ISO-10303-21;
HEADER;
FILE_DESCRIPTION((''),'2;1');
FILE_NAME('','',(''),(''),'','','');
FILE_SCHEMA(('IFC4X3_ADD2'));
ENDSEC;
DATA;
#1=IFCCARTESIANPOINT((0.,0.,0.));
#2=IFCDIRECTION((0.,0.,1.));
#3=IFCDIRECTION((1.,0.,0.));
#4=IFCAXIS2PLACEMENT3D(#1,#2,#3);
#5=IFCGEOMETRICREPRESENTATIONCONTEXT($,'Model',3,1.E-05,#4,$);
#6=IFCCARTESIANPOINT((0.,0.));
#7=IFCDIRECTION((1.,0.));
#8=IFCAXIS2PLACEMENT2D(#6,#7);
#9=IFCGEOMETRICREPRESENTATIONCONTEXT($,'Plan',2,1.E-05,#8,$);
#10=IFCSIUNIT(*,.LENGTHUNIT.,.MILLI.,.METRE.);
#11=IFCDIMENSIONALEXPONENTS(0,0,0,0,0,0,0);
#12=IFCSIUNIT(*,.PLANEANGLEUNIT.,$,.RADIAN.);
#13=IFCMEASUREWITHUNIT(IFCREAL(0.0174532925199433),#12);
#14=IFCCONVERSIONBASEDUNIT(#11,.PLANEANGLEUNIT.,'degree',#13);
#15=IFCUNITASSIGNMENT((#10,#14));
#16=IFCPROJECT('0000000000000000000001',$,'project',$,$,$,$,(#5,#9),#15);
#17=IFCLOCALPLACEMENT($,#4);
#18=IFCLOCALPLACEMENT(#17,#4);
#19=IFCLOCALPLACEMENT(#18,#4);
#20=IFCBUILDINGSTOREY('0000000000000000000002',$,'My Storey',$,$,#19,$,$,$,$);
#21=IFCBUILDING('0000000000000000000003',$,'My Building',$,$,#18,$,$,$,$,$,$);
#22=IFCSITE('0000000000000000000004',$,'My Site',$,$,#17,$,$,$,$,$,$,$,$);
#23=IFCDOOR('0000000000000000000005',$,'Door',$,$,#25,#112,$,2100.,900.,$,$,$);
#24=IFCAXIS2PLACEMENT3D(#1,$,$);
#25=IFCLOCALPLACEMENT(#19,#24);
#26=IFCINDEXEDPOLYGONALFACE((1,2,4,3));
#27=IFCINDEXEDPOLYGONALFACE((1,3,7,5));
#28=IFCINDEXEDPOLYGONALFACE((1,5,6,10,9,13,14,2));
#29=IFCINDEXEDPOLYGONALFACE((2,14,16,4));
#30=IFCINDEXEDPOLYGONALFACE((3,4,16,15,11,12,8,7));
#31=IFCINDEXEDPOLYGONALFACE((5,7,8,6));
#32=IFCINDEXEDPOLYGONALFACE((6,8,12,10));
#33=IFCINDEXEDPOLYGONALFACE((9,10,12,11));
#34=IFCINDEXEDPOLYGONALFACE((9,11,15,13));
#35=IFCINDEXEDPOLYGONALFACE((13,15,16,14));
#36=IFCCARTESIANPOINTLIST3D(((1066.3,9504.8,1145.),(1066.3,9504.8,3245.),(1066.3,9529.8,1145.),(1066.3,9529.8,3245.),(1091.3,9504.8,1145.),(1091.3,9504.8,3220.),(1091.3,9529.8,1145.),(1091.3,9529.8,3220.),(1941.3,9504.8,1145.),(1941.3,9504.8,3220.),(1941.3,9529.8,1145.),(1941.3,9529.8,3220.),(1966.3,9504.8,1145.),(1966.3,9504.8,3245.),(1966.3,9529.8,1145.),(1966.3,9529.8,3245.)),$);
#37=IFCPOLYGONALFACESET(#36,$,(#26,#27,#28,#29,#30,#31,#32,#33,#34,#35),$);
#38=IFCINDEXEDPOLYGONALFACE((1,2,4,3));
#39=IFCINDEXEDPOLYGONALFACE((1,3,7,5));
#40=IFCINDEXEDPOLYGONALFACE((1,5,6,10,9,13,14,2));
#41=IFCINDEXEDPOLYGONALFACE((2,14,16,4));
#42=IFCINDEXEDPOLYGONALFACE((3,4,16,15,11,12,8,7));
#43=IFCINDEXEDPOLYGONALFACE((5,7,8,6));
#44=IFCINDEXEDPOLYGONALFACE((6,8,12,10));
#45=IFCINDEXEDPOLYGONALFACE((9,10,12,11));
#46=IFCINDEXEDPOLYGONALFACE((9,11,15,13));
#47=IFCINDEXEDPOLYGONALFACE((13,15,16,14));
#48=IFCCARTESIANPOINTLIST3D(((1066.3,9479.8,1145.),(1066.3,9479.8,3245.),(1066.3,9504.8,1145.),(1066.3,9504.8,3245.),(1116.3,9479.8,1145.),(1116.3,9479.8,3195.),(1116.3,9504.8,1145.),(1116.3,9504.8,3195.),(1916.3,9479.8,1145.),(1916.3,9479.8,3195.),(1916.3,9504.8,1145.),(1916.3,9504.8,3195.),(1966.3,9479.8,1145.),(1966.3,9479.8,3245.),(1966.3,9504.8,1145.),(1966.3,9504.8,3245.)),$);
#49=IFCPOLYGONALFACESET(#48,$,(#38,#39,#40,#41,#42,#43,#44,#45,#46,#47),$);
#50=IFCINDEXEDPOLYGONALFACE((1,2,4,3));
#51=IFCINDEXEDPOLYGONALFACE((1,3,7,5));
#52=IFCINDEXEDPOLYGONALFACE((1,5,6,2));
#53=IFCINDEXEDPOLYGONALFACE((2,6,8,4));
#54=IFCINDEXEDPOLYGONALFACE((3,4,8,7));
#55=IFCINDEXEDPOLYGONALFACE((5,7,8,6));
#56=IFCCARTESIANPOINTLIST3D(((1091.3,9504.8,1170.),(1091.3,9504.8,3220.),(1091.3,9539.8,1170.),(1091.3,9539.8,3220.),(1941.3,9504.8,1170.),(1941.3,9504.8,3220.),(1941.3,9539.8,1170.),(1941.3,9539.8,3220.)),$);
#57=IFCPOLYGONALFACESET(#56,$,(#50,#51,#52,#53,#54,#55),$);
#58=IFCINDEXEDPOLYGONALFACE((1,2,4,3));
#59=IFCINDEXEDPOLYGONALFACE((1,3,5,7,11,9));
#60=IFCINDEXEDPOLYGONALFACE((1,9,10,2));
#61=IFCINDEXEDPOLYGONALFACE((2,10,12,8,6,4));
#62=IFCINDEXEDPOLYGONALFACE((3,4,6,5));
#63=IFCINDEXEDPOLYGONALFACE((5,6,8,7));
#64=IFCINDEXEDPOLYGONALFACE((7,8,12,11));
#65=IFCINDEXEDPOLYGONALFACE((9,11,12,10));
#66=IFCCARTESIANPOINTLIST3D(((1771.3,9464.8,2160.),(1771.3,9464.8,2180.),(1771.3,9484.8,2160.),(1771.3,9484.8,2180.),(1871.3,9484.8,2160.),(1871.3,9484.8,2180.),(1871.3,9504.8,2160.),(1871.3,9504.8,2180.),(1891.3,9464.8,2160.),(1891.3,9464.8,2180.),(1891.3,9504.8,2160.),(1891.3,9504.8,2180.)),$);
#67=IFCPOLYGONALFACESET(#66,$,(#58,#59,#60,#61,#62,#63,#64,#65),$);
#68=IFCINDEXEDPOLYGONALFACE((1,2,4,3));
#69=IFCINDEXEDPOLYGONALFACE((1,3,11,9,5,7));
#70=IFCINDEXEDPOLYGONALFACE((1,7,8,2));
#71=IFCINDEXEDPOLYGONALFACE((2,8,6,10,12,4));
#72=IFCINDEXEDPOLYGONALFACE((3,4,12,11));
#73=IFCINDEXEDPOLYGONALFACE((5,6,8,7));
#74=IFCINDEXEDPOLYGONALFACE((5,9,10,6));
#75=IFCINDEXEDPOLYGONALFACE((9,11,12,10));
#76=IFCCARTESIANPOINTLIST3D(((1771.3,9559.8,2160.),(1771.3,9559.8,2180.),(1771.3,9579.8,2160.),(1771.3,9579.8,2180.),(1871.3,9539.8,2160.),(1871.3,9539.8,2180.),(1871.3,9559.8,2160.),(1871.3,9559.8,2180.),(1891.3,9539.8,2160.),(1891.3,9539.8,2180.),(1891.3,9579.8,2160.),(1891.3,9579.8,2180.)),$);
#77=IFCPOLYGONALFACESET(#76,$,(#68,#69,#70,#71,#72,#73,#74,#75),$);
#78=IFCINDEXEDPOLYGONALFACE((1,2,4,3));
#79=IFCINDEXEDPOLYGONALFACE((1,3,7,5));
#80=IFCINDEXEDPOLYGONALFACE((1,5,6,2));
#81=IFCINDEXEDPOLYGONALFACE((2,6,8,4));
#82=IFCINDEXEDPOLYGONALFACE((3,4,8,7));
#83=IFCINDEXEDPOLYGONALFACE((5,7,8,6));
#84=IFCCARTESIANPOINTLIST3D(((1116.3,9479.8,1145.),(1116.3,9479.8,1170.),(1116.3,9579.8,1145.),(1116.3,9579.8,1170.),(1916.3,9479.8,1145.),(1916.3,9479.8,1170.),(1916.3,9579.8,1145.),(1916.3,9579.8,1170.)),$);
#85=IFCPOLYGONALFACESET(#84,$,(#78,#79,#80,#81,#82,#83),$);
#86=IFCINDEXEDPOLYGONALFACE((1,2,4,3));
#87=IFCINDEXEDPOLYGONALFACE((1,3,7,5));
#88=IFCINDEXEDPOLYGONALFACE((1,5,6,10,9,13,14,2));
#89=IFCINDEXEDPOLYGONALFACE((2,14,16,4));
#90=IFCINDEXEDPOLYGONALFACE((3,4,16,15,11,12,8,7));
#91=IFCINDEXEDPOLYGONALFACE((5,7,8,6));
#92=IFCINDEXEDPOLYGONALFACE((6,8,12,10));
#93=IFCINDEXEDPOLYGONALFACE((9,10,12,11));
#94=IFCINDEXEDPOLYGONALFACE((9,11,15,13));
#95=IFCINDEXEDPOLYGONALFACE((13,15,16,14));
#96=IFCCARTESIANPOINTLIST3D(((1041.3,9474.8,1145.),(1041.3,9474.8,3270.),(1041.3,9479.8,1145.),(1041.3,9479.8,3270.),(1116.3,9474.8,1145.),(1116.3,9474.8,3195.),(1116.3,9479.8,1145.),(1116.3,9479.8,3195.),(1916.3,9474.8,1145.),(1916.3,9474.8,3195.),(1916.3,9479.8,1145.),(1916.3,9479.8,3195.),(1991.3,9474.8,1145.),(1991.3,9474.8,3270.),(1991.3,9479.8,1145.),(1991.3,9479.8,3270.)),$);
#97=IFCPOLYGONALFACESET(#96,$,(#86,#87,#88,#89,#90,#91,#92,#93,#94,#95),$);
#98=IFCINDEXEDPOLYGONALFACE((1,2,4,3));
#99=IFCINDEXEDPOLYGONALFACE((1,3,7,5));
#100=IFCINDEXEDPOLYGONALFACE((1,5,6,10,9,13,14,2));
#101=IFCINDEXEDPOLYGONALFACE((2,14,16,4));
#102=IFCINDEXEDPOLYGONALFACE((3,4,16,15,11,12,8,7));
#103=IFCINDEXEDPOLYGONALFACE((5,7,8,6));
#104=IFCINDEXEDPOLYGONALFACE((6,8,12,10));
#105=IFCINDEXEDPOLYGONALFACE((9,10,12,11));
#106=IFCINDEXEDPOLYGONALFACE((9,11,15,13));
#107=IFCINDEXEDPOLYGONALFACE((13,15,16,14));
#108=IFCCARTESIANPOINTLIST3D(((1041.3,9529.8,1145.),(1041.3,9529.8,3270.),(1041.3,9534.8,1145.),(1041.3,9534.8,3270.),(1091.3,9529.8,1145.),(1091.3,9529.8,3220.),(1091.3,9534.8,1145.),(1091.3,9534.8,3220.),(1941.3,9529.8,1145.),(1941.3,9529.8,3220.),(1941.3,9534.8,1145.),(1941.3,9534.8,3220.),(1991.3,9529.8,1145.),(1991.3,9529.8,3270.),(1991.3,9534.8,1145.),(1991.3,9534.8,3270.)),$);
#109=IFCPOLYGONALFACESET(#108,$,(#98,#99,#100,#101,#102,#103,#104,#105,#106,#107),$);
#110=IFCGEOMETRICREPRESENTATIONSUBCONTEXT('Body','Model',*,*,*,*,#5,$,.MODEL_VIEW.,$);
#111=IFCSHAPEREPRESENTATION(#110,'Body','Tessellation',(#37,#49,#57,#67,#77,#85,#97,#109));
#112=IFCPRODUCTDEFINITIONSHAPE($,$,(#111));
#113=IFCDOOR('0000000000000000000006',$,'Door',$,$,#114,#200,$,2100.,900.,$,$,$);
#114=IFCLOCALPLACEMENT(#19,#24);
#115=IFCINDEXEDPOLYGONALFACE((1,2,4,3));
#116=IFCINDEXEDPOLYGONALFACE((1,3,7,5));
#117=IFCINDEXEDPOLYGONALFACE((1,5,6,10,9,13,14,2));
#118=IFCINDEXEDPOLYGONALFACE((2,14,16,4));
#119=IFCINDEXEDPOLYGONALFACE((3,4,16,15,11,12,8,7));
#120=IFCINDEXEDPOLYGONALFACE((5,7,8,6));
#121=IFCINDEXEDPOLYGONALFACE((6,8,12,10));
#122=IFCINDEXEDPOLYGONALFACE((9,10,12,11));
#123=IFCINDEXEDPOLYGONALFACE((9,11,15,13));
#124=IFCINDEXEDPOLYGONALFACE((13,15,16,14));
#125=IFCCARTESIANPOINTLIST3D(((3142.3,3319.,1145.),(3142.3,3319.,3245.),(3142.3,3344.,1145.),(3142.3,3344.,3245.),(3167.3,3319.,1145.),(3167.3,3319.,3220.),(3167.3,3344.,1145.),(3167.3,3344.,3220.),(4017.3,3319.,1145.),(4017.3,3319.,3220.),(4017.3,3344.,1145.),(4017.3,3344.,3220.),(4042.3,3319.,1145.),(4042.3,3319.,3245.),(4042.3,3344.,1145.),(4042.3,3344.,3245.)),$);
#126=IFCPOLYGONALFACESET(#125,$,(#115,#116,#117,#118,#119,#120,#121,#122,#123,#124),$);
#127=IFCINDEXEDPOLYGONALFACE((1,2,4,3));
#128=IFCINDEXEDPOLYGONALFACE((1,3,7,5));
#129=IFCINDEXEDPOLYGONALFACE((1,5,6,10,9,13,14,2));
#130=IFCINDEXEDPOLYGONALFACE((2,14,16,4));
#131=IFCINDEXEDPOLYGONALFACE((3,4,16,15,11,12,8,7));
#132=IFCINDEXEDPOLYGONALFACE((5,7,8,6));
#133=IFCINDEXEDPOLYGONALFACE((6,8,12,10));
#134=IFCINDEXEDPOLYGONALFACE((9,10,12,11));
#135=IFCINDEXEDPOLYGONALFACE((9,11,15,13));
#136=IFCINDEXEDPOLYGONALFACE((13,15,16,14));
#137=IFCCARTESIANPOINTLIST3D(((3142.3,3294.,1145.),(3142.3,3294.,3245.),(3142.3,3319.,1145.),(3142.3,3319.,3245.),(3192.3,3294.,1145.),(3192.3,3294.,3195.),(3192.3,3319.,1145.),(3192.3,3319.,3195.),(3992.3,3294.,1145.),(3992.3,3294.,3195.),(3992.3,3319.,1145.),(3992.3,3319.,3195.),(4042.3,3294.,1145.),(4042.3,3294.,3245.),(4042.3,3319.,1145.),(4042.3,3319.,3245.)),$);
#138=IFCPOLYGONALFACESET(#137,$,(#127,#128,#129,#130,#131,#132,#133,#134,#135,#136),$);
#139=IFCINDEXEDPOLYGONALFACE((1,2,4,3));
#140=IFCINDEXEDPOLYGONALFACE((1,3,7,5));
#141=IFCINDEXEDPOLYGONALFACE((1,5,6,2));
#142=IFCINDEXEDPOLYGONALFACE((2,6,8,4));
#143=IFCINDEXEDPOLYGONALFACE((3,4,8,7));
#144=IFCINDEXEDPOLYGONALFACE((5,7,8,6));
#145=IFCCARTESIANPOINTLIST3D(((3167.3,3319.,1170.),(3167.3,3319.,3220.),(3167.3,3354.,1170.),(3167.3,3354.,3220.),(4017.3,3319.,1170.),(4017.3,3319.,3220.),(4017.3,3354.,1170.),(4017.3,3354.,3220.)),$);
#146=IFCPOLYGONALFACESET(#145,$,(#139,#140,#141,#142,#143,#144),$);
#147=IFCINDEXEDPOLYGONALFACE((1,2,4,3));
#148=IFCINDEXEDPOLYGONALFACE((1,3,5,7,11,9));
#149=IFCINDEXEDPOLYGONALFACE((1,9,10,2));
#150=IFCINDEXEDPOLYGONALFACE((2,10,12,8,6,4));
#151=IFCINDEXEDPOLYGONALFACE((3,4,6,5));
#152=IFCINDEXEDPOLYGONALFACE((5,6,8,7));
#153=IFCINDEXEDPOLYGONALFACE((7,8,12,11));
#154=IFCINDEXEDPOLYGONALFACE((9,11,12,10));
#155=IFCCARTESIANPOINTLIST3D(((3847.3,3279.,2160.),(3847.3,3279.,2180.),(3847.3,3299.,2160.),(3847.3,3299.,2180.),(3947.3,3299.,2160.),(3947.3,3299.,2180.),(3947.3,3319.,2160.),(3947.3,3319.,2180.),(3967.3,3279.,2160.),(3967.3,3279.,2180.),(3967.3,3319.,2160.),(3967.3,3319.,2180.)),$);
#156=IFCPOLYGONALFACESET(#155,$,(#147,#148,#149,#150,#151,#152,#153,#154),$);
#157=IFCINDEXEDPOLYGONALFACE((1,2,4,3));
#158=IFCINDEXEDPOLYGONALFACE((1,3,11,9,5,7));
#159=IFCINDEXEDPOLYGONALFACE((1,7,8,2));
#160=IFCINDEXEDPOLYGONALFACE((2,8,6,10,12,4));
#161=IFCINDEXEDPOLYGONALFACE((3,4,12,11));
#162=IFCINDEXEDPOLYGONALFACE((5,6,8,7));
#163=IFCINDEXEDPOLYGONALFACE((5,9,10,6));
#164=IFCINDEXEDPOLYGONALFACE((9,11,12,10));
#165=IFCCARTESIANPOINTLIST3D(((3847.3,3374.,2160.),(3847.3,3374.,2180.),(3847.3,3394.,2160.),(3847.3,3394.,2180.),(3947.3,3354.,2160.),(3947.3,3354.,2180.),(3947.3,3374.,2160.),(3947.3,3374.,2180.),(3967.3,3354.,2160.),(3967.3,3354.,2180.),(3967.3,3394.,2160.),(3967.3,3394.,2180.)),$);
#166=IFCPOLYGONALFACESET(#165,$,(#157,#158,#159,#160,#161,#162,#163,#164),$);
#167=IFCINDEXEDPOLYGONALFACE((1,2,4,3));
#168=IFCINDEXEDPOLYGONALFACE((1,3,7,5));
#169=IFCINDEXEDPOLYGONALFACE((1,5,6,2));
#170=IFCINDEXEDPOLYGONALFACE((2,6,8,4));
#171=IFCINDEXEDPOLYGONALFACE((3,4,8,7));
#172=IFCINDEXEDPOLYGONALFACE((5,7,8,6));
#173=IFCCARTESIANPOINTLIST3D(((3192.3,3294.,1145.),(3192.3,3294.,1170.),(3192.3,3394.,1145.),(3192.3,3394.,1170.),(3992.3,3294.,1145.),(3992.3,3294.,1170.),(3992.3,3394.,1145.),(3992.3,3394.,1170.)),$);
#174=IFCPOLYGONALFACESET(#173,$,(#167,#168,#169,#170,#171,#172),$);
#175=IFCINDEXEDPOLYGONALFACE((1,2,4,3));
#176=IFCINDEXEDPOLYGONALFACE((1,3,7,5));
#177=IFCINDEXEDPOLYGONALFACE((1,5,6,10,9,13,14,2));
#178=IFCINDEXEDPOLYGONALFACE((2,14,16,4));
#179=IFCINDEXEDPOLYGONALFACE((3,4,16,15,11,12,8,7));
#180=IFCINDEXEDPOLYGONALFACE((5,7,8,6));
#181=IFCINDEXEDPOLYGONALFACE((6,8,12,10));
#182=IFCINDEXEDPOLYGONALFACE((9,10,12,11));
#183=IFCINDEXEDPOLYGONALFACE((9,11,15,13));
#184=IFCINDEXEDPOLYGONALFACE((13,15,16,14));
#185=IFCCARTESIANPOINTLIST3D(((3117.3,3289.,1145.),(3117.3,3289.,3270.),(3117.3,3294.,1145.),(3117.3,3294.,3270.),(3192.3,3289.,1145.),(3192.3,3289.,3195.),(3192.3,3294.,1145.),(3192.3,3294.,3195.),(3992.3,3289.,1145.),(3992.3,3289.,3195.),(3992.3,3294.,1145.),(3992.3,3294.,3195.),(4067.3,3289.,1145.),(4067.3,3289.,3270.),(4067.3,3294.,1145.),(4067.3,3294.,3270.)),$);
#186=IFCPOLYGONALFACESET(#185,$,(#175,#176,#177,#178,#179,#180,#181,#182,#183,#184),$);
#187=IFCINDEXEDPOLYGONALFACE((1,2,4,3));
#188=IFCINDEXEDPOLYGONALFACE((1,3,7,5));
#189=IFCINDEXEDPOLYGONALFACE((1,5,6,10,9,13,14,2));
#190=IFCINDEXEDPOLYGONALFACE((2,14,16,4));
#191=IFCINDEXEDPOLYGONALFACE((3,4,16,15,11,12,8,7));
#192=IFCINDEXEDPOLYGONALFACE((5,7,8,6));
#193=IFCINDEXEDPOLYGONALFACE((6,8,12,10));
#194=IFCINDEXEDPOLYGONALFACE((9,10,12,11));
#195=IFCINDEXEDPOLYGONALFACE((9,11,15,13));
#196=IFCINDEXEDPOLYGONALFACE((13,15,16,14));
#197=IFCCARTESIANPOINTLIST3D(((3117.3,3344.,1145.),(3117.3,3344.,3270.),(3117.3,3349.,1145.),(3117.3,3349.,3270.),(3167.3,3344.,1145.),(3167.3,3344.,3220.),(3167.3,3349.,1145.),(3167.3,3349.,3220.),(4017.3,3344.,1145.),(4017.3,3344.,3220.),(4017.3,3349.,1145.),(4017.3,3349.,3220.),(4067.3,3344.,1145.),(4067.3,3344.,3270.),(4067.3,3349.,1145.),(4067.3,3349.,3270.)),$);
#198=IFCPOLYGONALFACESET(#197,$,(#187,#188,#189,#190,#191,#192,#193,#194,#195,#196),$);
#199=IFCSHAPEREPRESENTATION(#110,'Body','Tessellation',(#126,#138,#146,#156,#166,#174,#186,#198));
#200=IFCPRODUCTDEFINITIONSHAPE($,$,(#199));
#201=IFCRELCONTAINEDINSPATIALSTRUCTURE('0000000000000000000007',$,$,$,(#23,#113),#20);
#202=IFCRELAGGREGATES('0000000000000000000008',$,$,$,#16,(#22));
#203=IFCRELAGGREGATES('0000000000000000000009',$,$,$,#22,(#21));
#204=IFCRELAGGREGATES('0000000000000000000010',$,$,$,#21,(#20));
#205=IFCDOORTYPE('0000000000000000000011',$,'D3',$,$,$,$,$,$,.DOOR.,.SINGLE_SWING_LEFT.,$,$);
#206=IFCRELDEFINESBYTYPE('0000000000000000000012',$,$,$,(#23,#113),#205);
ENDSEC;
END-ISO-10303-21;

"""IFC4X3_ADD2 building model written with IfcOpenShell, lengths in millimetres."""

from ifc_helpers import new_model, entity, si_unit, converted_unit, frame, origin_with_axes, origin_2d_with_axis, place, context, subcontext, project, spatial, line, indexed_curve, outline, extrude, shape, source, transform, mapped, type_object, type_shapes, element, save


model = new_model("IFC4X3_ADD2")

# Units and contexts
model_context = context("Model", 3, precision=1e-05, world=origin_with_axes())
plan_context = context("Plan", 2, precision=1e-05, world=origin_2d_with_axis())
body_context_1 = subcontext(model_context, "Body", "Model", "MODEL_VIEW")
body_context_2 = subcontext(plan_context, "Body", "Plan", "PLAN_VIEW")
ifc_project = project(units=[si_unit("LENGTHUNIT", "METRE", prefix="MILLI"), converted_unit("PLANEANGLEUNIT", "degree", entity("IfcReal", 0.0174532925199433), si_unit("PLANEANGLEUNIT", "RADIAN"), dimensions=[0, 0, 0, 0, 0, 0, 0])], contexts=[model_context, plan_context])

# Site, building, storey
site_placement = place(None, origin_with_axes())
site = spatial("IfcSite", under=ifc_project, at=site_placement, Name="My Site")
building_placement = place(site_placement, origin_with_axes())
building = spatial("IfcBuilding", under=site, at=building_placement, Name="My Building")
storey_placement = place(building_placement, origin_with_axes())
storey = spatial("IfcBuildingStorey", under=building, at=storey_placement, Name="My Storey")

# Doors
door_type = type_object("IfcDoorType", Name="D3", OperationType="SINGLE_SWING_LEFT", PredefinedType="DOOR")
shared_shape_1 = source(origin_with_axes(), body_context_1, "Body", "SweptSolid", [
    extrude(outline(indexed_curve([(0.0, 0.0), (0.0, 2100.0), (900.0, 2100.0), (900.0, 0.0), (875.0, 0.0), (875.0, 2075.0), (25.0, 2075.0), (25.0, 0.0)], segments=[line(1, 2, 3, 4, 5, 6, 7, 8, 1)])), frame((0.0, 25.0, 0.0), z_axis=(0.0, -1.0, 0.0), x_axis=(1.0, 0.0, 0.0)), (0.0, 0.0, -1.0), 25.0),
    extrude(outline(indexed_curve([(0.0, 0.0), (0.0, 2100.0), (900.0, 2100.0), (900.0, 0.0), (850.0, 0.0), (850.0, 2050.0), (50.0, 2050.0), (50.0, 0.0)], segments=[line(1, 2, 3, 4, 5, 6, 7, 8, 1)])), frame((0.0, 0.0, 0.0), z_axis=(0.0, -1.0, 0.0), x_axis=(1.0, 0.0, 0.0)), (0.0, 0.0, -1.0), 25.0),
    extrude(outline(indexed_curve([(0.0, 0.0), (850.0, 0.0), (850.0, 35.0), (0.0, 35.0)], segments=[line(1, 2, 3, 4, 1)])), frame((25.0, 25.0, 25.0), z_axis=(0.0, 0.0, 1.0), x_axis=(1.0, 0.0, 0.0)), (0.0, 0.0, 1.0), 2050.0),
    extrude(outline(indexed_curve([(0.0, 0.0), (0.0, -40.0), (-120.0, -40.0), (-120.0, -20.0), (-20.0, -20.0), (-20.0, 0.0)], segments=[line(1, 2, 3, 4, 5, 6, 1)])), frame((825.0, 25.0, 1015.0), z_axis=(0.0, 0.0, 1.0), x_axis=(1.0, 0.0, 0.0)), (0.0, 0.0, 1.0), 20.0),
    extrude(outline(indexed_curve([(0.0, 0.0), (0.0, 40.0), (-120.0, 40.0), (-120.0, 20.0), (-20.0, 20.0), (-20.0, 0.0)], segments=[line(1, 2, 3, 4, 5, 6, 1)])), frame((825.0, 60.0, 1015.0), z_axis=(0.0, 0.0, 1.0), x_axis=(1.0, 0.0, 0.0)), (0.0, 0.0, 1.0), 20.0),
    extrude(outline(indexed_curve([(0.0, 0.0), (800.0, 0.0), (800.0, 100.0), (0.0, 100.0)], segments=[line(1, 2, 3, 4, 1)])), frame((50.0, 0.0, 0.0), z_axis=(0.0, 0.0, 1.0), x_axis=(1.0, 0.0, 0.0)), (0.0, 0.0, 1.0), 25.0),
    extrude(outline(indexed_curve([(0.0, 0.0), (0.0, 2125.0), (950.0, 2125.0), (950.0, 0.0), (875.0, 0.0), (875.0, 2050.0), (75.0, 2050.0), (75.0, 0.0)], segments=[line(1, 2, 3, 4, 5, 6, 7, 8, 1)])), frame((-25.0, -5.0, 0.0), z_axis=(0.0, -1.0, 0.0), x_axis=(1.0, 0.0, 0.0)), (0.0, 0.0, -1.0), 5.0),
    extrude(outline(indexed_curve([(0.0, 0.0), (0.0, 2125.0), (950.0, 2125.0), (950.0, 0.0), (900.0, 0.0), (900.0, 2075.0), (50.0, 2075.0), (50.0, 0.0)], segments=[line(1, 2, 3, 4, 5, 6, 7, 8, 1)])), frame((-25.0, 50.0, 0.0), z_axis=(0.0, -1.0, 0.0), x_axis=(1.0, 0.0, 0.0)), (0.0, 0.0, -1.0), 5.0),
])
shared_shape_2 = source(origin_with_axes(), body_context_2, "Body", "Curve2D", [
    entity("IfcIndexedPolyCurve", entity("IfcCartesianPointList2D", [[0.0, 0.0], [0.0, 50.0], [25.0, 50.0], [25.0, 25.0], [50.0, 25.0], [50.0, 0.0]]), [entity("IfcLineIndex", [1, 2, 3, 4, 5, 6, 1])]),
    entity("IfcIndexedPolyCurve", entity("IfcCartesianPointList2D", [[900.0, 0.0], [900.0, 50.0], [875.0, 50.0], [875.0, 25.0], [850.0, 25.0], [850.0, 0.0]]), [entity("IfcLineIndex", [1, 2, 3, 4, 5, 6, 1])]),
    entity("IfcTrimmedCurve", entity("IfcEllipse", entity("IfcAxis2Placement2D", entity("IfcCartesianPoint", [60.0, 50.0]), entity("IfcDirection", [1.0, 0.0])), 815.0, 850.0), [entity("IfcCartesianPoint", [875.0, 50.0])], [entity("IfcCartesianPoint", [60.0, 900.0])], True, "CARTESIAN"),
    entity("IfcIndexedPolyCurve", entity("IfcCartesianPointList2D", [[25.0, 50.0], [60.0, 50.0], [60.0, 900.0], [25.0, 900.0]]), [entity("IfcLineIndex", [1, 2, 3, 4, 1])]),
])
type_shapes(door_type, [shared_shape_1, shared_shape_2])
for number, where, z_axis, x_axis, name in (
    (1, (1066.3, 9479.8, 1145.0), (0.0, 0.0, 1.0), (1.0, 0.0, 0.0), "Door"),
    (2, (3142.3, 3294.0, 1145.0), (0.0, 0.0, 1.0), (1.0, 0.0, 0.0), "Door"),
):
    element("IfcDoor", number, at=place(storey_placement, frame(where, z_axis=z_axis, x_axis=x_axis)), inside=storey, type_object=door_type, Name=name, OverallHeight=2100.0, OverallWidth=900.0, shapes=[
        shape(body_context_1, "Body", "MappedRepresentation", [mapped(shared_shape_1, transform((0.0, 0.0, 0.0), x_axis=(1.0, 0.0, 0.0), y_axis=(0.0, 1.0, 0.0), z_axis=(0.0, 0.0, 1.0), scale=1.0))]),
        shape(body_context_2, "Body", "MappedRepresentation", [mapped(shared_shape_2, transform((0.0, 0.0, 0.0), x_axis=(1.0, 0.0, 0.0), y_axis=(0.0, 1.0, 0.0), z_axis=(0.0, 0.0, 1.0), scale=1.0))]),
    ])

save(model, "model.ifc")
